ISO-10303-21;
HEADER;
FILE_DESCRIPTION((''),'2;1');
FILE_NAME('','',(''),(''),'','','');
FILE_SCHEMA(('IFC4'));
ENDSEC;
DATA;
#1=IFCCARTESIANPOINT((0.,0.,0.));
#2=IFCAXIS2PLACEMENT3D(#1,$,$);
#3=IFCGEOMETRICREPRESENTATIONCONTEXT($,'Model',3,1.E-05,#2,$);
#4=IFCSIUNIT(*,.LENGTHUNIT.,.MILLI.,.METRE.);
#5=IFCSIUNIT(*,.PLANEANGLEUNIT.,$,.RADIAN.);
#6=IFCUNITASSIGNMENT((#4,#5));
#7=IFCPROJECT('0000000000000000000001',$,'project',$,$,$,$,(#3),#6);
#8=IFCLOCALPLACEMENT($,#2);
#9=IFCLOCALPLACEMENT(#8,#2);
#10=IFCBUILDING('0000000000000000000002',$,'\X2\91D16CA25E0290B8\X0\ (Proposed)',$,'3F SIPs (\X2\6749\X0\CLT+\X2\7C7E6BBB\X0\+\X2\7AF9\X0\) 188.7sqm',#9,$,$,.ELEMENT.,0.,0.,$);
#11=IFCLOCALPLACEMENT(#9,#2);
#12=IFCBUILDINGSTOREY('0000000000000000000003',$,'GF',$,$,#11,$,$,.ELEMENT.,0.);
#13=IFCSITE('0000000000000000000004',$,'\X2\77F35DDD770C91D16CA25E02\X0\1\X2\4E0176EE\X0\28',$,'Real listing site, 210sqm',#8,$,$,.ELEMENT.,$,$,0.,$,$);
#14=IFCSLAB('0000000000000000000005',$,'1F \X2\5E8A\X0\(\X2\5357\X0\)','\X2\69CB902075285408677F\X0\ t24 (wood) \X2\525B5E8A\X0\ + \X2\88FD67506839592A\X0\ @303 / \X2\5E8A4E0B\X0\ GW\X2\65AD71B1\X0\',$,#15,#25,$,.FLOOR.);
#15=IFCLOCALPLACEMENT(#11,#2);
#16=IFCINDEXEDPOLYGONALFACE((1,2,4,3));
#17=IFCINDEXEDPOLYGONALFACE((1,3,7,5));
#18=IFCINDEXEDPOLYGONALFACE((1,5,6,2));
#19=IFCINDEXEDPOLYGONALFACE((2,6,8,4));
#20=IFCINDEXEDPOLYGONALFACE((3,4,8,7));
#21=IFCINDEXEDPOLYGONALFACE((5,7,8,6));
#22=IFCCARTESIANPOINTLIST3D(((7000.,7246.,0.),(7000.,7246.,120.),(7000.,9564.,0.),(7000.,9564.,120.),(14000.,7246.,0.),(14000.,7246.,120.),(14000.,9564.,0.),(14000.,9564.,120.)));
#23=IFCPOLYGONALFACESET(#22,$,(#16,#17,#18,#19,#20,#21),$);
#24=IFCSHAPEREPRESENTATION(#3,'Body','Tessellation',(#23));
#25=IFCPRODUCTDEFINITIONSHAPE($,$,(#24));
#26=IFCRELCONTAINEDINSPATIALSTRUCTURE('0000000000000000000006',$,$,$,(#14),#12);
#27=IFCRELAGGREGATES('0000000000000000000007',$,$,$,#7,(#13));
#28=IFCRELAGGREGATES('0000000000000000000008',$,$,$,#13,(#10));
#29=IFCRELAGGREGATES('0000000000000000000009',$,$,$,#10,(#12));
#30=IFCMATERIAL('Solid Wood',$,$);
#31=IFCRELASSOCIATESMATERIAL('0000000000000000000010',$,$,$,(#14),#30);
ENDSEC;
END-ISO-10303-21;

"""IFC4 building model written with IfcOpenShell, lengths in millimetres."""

from ifc_helpers import new_model, si_unit, frame, frame_2d, origin, place, context, project, spatial, rectangle, extrude, material, element, save


model = new_model("IFC4")

# Units and contexts
model_context = context("Model", 3, precision=1e-05, world=origin())
ifc_project = project(units=[si_unit("LENGTHUNIT", "METRE", prefix="MILLI"), si_unit("PLANEANGLEUNIT", "RADIAN")], contexts=[model_context])

# Site, building, storey
site_placement = place(None, origin())
site = spatial("IfcSite", under=ifc_project, at=site_placement, Name="石川県金沢市1丁目28", ObjectType="Real listing site, 210sqm", CompositionType="ELEMENT", RefElevation=0.0)
building_placement = place(site_placement, origin())
building = spatial("IfcBuilding", under=site, at=building_placement, Name="金沢市邸 (Proposed)", ObjectType="3F SIPs (杉CLT+籾殻+竹) 188.7sqm", CompositionType="ELEMENT", ElevationOfRefHeight=0.0, ElevationOfTerrain=0.0)
storey_placement = place(building_placement, origin())
storey = spatial("IfcBuildingStorey", under=building, at=storey_placement, Name="GF", CompositionType="ELEMENT", Elevation=0.0)

# Slab
ifc_material_1 = material(Name="Solid Wood")
slab_1_placement = place(storey_placement, frame((3500.0, 3623.0, 0.0)))
element("IfcSlab", 1, at=slab_1_placement, inside=storey, material=ifc_material_1, Name="1F 床(南)", Description="構造用合板 t24 (wood) 剛床 + 製材根太 @303 / 床下 GW断熱", PredefinedType="FLOOR", context=model_context, shape_type="SweptSolid", body=[
    extrude(rectangle(XDim=7000.0, YDim=2318.0, at=frame_2d((3500.0, 1159.0))), frame((3500.0, 3623.0, 0.0)), (0.0, 0.0, 1.0), 120.0),
])

save(model, "model.ifc")
